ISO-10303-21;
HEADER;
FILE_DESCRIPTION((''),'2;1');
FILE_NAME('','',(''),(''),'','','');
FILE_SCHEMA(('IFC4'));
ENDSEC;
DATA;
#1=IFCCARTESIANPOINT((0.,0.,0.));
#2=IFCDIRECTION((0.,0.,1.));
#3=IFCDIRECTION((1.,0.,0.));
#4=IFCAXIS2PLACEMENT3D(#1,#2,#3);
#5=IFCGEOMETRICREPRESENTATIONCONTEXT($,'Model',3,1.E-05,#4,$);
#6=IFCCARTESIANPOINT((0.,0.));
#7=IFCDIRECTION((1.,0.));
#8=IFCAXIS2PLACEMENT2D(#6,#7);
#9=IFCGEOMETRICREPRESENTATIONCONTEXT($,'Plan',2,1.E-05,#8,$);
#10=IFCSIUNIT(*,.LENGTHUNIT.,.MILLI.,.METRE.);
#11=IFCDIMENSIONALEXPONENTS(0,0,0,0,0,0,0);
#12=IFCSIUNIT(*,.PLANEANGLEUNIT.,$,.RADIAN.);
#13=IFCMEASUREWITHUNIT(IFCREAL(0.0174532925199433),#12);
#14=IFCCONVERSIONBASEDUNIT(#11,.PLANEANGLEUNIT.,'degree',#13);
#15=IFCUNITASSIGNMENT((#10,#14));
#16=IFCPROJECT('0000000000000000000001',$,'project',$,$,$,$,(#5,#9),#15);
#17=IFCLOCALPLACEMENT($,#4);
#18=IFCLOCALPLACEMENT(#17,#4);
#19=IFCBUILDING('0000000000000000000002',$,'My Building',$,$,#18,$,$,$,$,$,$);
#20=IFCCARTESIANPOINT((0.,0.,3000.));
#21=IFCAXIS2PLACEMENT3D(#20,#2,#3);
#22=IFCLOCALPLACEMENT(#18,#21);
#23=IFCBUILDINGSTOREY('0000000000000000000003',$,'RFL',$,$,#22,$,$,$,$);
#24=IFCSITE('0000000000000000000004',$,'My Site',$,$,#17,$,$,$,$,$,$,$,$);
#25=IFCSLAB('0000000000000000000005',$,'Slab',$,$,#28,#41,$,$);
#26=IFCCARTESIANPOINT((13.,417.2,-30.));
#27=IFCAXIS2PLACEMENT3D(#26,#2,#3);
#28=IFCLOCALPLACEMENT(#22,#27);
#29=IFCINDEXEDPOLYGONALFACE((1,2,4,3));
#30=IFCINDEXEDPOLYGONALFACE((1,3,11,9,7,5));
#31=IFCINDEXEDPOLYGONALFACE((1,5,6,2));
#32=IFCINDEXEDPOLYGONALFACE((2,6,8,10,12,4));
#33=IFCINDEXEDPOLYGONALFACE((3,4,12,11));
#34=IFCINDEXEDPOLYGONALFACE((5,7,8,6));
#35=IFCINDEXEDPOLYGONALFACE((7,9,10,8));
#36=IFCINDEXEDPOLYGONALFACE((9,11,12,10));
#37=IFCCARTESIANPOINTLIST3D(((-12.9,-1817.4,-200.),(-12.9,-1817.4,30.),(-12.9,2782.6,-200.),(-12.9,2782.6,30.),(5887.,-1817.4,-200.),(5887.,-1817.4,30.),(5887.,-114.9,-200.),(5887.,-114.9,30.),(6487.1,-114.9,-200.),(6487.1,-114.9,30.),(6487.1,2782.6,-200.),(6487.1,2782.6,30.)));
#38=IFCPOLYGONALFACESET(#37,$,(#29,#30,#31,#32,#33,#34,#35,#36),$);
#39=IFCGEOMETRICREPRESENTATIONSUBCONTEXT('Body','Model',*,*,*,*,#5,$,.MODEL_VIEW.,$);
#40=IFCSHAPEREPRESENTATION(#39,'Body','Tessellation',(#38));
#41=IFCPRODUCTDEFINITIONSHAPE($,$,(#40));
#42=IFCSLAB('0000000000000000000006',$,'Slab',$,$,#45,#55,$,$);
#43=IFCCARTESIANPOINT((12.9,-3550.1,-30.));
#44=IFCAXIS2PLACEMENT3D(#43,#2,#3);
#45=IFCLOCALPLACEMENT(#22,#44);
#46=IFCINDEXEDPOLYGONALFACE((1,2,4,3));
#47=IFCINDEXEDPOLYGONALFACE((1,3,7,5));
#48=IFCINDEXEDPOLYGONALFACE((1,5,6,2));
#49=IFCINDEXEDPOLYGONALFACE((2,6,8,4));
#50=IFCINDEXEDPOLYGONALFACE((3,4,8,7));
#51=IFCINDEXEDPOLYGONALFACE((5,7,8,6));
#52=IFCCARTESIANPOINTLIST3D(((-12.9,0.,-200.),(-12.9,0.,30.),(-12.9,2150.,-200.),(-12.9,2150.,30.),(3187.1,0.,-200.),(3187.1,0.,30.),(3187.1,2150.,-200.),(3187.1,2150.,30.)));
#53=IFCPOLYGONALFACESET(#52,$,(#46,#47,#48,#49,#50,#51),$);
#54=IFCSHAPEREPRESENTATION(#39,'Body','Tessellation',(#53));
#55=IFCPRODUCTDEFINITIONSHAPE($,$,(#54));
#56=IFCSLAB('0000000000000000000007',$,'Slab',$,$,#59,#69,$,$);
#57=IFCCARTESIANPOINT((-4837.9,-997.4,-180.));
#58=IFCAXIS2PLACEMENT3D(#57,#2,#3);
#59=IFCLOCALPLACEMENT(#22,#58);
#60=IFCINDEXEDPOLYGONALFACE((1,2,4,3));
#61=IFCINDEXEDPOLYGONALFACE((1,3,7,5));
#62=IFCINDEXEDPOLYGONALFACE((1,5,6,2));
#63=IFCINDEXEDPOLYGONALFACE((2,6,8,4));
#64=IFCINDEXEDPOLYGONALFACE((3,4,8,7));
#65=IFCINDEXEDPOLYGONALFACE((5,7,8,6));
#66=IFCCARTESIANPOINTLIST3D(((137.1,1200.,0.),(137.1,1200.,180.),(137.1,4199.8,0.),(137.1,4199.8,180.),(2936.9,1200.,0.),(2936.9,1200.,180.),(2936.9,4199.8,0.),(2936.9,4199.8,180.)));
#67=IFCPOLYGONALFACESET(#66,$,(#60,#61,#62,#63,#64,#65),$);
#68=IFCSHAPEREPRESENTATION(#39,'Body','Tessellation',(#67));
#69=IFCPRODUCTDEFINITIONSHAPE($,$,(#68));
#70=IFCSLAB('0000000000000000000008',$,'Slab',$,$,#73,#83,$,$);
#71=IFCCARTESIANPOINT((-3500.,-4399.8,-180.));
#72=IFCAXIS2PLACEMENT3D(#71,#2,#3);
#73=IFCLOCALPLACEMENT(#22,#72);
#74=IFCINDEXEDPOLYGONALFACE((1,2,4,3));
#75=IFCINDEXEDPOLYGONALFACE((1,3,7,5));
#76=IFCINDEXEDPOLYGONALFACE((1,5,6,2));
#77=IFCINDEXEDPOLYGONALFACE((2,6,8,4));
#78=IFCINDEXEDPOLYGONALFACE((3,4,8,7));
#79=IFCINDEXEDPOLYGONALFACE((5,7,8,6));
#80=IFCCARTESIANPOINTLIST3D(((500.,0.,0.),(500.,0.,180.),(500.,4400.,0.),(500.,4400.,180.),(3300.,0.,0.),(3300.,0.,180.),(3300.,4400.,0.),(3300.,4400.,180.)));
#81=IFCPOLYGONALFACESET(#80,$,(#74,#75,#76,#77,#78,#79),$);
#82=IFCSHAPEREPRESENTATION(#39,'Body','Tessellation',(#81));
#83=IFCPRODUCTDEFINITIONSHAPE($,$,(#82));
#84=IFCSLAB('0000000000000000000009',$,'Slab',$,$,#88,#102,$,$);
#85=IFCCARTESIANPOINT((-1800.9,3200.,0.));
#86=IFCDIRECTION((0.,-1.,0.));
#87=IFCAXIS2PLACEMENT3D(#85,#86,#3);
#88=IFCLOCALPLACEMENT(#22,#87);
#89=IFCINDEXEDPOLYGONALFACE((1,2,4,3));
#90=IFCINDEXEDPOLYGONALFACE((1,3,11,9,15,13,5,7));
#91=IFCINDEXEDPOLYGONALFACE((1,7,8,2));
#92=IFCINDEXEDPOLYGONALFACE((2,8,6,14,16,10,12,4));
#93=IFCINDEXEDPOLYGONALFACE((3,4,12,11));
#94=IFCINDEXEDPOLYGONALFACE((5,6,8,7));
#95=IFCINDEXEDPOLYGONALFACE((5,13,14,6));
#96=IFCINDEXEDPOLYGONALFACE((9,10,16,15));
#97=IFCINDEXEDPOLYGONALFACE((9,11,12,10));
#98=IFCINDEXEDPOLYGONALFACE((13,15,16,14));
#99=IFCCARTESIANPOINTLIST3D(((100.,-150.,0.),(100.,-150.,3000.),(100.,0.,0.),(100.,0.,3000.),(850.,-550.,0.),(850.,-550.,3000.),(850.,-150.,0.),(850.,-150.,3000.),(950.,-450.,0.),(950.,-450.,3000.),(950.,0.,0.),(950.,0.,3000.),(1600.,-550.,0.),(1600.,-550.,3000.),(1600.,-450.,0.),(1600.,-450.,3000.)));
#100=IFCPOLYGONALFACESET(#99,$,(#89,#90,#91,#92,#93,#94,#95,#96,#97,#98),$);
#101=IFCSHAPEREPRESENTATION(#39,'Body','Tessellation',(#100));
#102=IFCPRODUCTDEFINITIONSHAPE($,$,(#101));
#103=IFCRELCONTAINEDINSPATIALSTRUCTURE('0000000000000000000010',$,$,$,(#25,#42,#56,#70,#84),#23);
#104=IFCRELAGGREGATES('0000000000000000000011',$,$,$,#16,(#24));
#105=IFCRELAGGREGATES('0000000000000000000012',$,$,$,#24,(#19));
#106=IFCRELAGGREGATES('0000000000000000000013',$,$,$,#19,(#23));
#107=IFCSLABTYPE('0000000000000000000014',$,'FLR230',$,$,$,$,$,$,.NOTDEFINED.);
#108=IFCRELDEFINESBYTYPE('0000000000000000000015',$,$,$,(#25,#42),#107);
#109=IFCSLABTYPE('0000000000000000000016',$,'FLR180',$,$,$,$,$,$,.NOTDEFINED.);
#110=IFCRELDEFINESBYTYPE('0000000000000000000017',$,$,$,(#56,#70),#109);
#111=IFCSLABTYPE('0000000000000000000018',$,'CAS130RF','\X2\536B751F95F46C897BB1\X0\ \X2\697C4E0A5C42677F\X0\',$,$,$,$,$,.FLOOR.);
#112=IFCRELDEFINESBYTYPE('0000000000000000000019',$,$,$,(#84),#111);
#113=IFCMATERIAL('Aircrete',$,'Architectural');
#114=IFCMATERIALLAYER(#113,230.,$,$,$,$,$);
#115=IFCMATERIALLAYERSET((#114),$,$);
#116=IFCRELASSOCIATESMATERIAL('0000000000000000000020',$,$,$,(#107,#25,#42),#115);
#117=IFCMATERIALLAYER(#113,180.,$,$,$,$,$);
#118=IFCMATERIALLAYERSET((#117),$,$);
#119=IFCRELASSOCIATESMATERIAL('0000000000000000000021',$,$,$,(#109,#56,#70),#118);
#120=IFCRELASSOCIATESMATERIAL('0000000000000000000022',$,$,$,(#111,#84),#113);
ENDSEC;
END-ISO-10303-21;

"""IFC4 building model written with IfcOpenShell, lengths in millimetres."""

from ifc_helpers import new_model, entity, si_unit, converted_unit, frame, origin_with_axes, origin_2d_with_axis, place, context, subcontext, project, spatial, indexed_curve, outline, extrude, material, layer, layer_set, layer_usage, material_profile, profile_set, profile_usage, type_object, element, save


model = new_model("IFC4")

# Units and contexts
model_context = context("Model", 3, precision=1e-05, world=origin_with_axes())
plan_context = context("Plan", 2, precision=1e-05, world=origin_2d_with_axis())
body_context = subcontext(model_context, "Body", "Model", "MODEL_VIEW")
ifc_project = project(units=[si_unit("LENGTHUNIT", "METRE", prefix="MILLI"), converted_unit("PLANEANGLEUNIT", "degree", entity("IfcReal", 0.0174532925199433), si_unit("PLANEANGLEUNIT", "RADIAN"), dimensions=[0, 0, 0, 0, 0, 0, 0])], contexts=[model_context, plan_context])

# Site, building, storey
site_placement = place(None, origin_with_axes())
site = spatial("IfcSite", under=ifc_project, at=site_placement, Name="My Site")
building_placement = place(site_placement, origin_with_axes())
building = spatial("IfcBuilding", under=site, at=building_placement, Name="My Building")
storey_placement = place(building_placement, frame((0.0, 0.0, 3000.0), z_axis=(0.0, 0.0, 1.0), x_axis=(1.0, 0.0, 0.0)))
storey = spatial("IfcBuildingStorey", under=building, at=storey_placement, Name="RFL")

# Shared definitions
ifc_material = material(Name="Aircrete", Category="Architectural")

# Slab, opening
ifc_layer_1 = layer(ifc_material, 230.0)
ifc_layer_set_1 = layer_set([ifc_layer_1])
ifc_layer_usage_1 = layer_usage(ifc_layer_set_1, "AXIS3", "POSITIVE", -200.0)
slab_type_1 = type_object("IfcSlabType", Name="FLR230", PredefinedType="NOTDEFINED", material=ifc_layer_set_1)
slab_1_placement = place(storey_placement, frame((13.0, 417.2, -30.0), z_axis=(0.0, 0.0, 1.0), x_axis=(1.0, 0.0, 0.0)))
slab_1 = element("IfcSlab", 1, at=slab_1_placement, inside=storey, type_object=slab_type_1, material=ifc_layer_usage_1, Name="Slab", context=body_context, shape_type="SweptSolid", body=[
    extrude(outline(indexed_curve([(-12.9, 2782.6), (6487.1, 2782.6), (6487.1, -1817.4), (-12.9, -1817.4), (-12.9, 2782.6)])), frame((0.0, 0.0, -200.0), z_axis=(0.0, 0.0, 1.0), x_axis=(1.0, 0.0, 0.0)), (0.0, 0.0, 1.0), 230.0),
])
opening_1_placement = place(slab_1_placement, frame((6487.1, -1817.4, -200.0), z_axis=(0.0, 0.0, 1.0), x_axis=(0.0, 1.0, 0.0)))
element("IfcOpeningElement", 2, at=opening_1_placement, cuts=slab_1, PredefinedType="OPENING", context=body_context, shape_type="SweptSolid", body=[
    extrude(outline(indexed_curve([(0.0, 600.1), (1702.4, 600.1), (1702.4, 0.0), (0.0, 0.0), (0.0, 600.1)])), origin_with_axes(), (0.0, 0.0, 1.0), 500.0),
])

# Slabs
ifc_layer_usage_2 = layer_usage(ifc_layer_set_1, "AXIS3", "POSITIVE", -200.0)
slab_2_placement = place(storey_placement, frame((12.9, -3550.1, -30.0), z_axis=(0.0, 0.0, 1.0), x_axis=(1.0, 0.0, 0.0)))
element("IfcSlab", 3, at=slab_2_placement, inside=storey, type_object=slab_type_1, material=ifc_layer_usage_2, Name="Slab", context=body_context, shape_type="SweptSolid", body=[
    extrude(outline(indexed_curve([(-12.9, 2150.0), (3187.1, 2150.0), (3187.1, 0.0), (-12.9, 0.0), (-12.9, 2150.0)])), frame((0.0, 0.0, -200.0), z_axis=(0.0, 0.0, 1.0), x_axis=(1.0, 0.0, 0.0)), (0.0, 0.0, 1.0), 230.0),
])
ifc_layer_2 = layer(ifc_material, 180.0)
ifc_layer_set_2 = layer_set([ifc_layer_2])
slab_type_2 = type_object("IfcSlabType", Name="FLR180", PredefinedType="NOTDEFINED", material=ifc_layer_set_2)
ifc_layer_usage_3 = layer_usage(ifc_layer_set_2, "AXIS3", "POSITIVE", 0.0)
slab_3_placement = place(storey_placement, frame((-4837.9, -997.4, -180.0), z_axis=(0.0, 0.0, 1.0), x_axis=(1.0, 0.0, 0.0)))
element("IfcSlab", 4, at=slab_3_placement, inside=storey, type_object=slab_type_2, material=ifc_layer_usage_3, Name="Slab", context=body_context, shape_type="SweptSolid", body=[
    extrude(outline(indexed_curve([(137.1, 4199.8), (2936.9, 4199.8), (2936.9, 1200.0), (137.1, 1200.0), (137.1, 4199.8)])), None, (0.0, 0.0, 1.0), 180.0),
])
ifc_layer_usage_4 = layer_usage(ifc_layer_set_2, "AXIS3", "POSITIVE", 0.0)
slab_4_placement = place(storey_placement, frame((-3500.0, -4399.8, -180.0), z_axis=(0.0, 0.0, 1.0), x_axis=(1.0, 0.0, 0.0)))
element("IfcSlab", 5, at=slab_4_placement, inside=storey, type_object=slab_type_2, material=ifc_layer_usage_4, Name="Slab", context=body_context, shape_type="SweptSolid", body=[
    extrude(outline(indexed_curve([(500.0, 0.0), (3300.0, 0.0), (3300.0, 4400.0), (500.0, 4400.0), (500.0, 0.0)])), None, (0.0, 0.0, 1.0), 180.0),
])

# Slab, opening
ifc_material_profile_1 = material_profile(ifc_material, outline(indexed_curve([(950.0, -450.0), (1600.0, -450.0), (1600.0, -550.0), (850.0, -550.0), (850.0, -150.0), (0.0, -150.0), (0.0, 0.0), (950.0, 0.0), (950.0, -450.0)])))
ifc_profile_set_1 = profile_set([ifc_material_profile_1])
ifc_profile_usage_1 = profile_usage(ifc_profile_set_1)
slab_type_3 = type_object("IfcSlabType", Name="CAS130RF", Description="卫生间沉箱 楼上层板", PredefinedType="FLOOR", material=ifc_profile_set_1)
slab_5_placement = place(storey_placement, frame((-1800.9, 3200.0, 0.0), z_axis=(0.0, -1.0, 0.0), x_axis=(1.0, 0.0, 0.0)))
slab_5 = element("IfcSlab", 6, at=slab_5_placement, inside=storey, type_object=slab_type_3, material=ifc_profile_usage_1, Name="Slab", context=body_context, shape_type="SweptSolid", body=[
    extrude(outline(indexed_curve([(950.0, -450.0), (1600.0, -450.0), (1600.0, -550.0), (850.0, -550.0), (850.0, -150.0), (0.0, -150.0), (0.0, 0.0), (950.0, 0.0), (950.0, -450.0)])), origin_with_axes(), (0.0, 0.0, 1.0), 3000.0),
])
opening_2_placement = place(slab_5_placement, frame((100.0, -180.0, 0.0), z_axis=(0.0, 1.0, 0.0), x_axis=(-1.0, 0.0, -0.000001)))
element("IfcOpeningElement", 7, at=opening_2_placement, cuts=slab_5, PredefinedType="OPENING", context=body_context, shape_type="SweptSolid", body=[
    extrude(outline(indexed_curve([(0.0, 0.0), (500.0, 0.0), (500.0, 3107.1), (0.0, 3107.1), (0.0, 0.0)])), origin_with_axes(), (0.0, 0.0, 1.0), 500.0),
])

save(model, "model.ifc")
